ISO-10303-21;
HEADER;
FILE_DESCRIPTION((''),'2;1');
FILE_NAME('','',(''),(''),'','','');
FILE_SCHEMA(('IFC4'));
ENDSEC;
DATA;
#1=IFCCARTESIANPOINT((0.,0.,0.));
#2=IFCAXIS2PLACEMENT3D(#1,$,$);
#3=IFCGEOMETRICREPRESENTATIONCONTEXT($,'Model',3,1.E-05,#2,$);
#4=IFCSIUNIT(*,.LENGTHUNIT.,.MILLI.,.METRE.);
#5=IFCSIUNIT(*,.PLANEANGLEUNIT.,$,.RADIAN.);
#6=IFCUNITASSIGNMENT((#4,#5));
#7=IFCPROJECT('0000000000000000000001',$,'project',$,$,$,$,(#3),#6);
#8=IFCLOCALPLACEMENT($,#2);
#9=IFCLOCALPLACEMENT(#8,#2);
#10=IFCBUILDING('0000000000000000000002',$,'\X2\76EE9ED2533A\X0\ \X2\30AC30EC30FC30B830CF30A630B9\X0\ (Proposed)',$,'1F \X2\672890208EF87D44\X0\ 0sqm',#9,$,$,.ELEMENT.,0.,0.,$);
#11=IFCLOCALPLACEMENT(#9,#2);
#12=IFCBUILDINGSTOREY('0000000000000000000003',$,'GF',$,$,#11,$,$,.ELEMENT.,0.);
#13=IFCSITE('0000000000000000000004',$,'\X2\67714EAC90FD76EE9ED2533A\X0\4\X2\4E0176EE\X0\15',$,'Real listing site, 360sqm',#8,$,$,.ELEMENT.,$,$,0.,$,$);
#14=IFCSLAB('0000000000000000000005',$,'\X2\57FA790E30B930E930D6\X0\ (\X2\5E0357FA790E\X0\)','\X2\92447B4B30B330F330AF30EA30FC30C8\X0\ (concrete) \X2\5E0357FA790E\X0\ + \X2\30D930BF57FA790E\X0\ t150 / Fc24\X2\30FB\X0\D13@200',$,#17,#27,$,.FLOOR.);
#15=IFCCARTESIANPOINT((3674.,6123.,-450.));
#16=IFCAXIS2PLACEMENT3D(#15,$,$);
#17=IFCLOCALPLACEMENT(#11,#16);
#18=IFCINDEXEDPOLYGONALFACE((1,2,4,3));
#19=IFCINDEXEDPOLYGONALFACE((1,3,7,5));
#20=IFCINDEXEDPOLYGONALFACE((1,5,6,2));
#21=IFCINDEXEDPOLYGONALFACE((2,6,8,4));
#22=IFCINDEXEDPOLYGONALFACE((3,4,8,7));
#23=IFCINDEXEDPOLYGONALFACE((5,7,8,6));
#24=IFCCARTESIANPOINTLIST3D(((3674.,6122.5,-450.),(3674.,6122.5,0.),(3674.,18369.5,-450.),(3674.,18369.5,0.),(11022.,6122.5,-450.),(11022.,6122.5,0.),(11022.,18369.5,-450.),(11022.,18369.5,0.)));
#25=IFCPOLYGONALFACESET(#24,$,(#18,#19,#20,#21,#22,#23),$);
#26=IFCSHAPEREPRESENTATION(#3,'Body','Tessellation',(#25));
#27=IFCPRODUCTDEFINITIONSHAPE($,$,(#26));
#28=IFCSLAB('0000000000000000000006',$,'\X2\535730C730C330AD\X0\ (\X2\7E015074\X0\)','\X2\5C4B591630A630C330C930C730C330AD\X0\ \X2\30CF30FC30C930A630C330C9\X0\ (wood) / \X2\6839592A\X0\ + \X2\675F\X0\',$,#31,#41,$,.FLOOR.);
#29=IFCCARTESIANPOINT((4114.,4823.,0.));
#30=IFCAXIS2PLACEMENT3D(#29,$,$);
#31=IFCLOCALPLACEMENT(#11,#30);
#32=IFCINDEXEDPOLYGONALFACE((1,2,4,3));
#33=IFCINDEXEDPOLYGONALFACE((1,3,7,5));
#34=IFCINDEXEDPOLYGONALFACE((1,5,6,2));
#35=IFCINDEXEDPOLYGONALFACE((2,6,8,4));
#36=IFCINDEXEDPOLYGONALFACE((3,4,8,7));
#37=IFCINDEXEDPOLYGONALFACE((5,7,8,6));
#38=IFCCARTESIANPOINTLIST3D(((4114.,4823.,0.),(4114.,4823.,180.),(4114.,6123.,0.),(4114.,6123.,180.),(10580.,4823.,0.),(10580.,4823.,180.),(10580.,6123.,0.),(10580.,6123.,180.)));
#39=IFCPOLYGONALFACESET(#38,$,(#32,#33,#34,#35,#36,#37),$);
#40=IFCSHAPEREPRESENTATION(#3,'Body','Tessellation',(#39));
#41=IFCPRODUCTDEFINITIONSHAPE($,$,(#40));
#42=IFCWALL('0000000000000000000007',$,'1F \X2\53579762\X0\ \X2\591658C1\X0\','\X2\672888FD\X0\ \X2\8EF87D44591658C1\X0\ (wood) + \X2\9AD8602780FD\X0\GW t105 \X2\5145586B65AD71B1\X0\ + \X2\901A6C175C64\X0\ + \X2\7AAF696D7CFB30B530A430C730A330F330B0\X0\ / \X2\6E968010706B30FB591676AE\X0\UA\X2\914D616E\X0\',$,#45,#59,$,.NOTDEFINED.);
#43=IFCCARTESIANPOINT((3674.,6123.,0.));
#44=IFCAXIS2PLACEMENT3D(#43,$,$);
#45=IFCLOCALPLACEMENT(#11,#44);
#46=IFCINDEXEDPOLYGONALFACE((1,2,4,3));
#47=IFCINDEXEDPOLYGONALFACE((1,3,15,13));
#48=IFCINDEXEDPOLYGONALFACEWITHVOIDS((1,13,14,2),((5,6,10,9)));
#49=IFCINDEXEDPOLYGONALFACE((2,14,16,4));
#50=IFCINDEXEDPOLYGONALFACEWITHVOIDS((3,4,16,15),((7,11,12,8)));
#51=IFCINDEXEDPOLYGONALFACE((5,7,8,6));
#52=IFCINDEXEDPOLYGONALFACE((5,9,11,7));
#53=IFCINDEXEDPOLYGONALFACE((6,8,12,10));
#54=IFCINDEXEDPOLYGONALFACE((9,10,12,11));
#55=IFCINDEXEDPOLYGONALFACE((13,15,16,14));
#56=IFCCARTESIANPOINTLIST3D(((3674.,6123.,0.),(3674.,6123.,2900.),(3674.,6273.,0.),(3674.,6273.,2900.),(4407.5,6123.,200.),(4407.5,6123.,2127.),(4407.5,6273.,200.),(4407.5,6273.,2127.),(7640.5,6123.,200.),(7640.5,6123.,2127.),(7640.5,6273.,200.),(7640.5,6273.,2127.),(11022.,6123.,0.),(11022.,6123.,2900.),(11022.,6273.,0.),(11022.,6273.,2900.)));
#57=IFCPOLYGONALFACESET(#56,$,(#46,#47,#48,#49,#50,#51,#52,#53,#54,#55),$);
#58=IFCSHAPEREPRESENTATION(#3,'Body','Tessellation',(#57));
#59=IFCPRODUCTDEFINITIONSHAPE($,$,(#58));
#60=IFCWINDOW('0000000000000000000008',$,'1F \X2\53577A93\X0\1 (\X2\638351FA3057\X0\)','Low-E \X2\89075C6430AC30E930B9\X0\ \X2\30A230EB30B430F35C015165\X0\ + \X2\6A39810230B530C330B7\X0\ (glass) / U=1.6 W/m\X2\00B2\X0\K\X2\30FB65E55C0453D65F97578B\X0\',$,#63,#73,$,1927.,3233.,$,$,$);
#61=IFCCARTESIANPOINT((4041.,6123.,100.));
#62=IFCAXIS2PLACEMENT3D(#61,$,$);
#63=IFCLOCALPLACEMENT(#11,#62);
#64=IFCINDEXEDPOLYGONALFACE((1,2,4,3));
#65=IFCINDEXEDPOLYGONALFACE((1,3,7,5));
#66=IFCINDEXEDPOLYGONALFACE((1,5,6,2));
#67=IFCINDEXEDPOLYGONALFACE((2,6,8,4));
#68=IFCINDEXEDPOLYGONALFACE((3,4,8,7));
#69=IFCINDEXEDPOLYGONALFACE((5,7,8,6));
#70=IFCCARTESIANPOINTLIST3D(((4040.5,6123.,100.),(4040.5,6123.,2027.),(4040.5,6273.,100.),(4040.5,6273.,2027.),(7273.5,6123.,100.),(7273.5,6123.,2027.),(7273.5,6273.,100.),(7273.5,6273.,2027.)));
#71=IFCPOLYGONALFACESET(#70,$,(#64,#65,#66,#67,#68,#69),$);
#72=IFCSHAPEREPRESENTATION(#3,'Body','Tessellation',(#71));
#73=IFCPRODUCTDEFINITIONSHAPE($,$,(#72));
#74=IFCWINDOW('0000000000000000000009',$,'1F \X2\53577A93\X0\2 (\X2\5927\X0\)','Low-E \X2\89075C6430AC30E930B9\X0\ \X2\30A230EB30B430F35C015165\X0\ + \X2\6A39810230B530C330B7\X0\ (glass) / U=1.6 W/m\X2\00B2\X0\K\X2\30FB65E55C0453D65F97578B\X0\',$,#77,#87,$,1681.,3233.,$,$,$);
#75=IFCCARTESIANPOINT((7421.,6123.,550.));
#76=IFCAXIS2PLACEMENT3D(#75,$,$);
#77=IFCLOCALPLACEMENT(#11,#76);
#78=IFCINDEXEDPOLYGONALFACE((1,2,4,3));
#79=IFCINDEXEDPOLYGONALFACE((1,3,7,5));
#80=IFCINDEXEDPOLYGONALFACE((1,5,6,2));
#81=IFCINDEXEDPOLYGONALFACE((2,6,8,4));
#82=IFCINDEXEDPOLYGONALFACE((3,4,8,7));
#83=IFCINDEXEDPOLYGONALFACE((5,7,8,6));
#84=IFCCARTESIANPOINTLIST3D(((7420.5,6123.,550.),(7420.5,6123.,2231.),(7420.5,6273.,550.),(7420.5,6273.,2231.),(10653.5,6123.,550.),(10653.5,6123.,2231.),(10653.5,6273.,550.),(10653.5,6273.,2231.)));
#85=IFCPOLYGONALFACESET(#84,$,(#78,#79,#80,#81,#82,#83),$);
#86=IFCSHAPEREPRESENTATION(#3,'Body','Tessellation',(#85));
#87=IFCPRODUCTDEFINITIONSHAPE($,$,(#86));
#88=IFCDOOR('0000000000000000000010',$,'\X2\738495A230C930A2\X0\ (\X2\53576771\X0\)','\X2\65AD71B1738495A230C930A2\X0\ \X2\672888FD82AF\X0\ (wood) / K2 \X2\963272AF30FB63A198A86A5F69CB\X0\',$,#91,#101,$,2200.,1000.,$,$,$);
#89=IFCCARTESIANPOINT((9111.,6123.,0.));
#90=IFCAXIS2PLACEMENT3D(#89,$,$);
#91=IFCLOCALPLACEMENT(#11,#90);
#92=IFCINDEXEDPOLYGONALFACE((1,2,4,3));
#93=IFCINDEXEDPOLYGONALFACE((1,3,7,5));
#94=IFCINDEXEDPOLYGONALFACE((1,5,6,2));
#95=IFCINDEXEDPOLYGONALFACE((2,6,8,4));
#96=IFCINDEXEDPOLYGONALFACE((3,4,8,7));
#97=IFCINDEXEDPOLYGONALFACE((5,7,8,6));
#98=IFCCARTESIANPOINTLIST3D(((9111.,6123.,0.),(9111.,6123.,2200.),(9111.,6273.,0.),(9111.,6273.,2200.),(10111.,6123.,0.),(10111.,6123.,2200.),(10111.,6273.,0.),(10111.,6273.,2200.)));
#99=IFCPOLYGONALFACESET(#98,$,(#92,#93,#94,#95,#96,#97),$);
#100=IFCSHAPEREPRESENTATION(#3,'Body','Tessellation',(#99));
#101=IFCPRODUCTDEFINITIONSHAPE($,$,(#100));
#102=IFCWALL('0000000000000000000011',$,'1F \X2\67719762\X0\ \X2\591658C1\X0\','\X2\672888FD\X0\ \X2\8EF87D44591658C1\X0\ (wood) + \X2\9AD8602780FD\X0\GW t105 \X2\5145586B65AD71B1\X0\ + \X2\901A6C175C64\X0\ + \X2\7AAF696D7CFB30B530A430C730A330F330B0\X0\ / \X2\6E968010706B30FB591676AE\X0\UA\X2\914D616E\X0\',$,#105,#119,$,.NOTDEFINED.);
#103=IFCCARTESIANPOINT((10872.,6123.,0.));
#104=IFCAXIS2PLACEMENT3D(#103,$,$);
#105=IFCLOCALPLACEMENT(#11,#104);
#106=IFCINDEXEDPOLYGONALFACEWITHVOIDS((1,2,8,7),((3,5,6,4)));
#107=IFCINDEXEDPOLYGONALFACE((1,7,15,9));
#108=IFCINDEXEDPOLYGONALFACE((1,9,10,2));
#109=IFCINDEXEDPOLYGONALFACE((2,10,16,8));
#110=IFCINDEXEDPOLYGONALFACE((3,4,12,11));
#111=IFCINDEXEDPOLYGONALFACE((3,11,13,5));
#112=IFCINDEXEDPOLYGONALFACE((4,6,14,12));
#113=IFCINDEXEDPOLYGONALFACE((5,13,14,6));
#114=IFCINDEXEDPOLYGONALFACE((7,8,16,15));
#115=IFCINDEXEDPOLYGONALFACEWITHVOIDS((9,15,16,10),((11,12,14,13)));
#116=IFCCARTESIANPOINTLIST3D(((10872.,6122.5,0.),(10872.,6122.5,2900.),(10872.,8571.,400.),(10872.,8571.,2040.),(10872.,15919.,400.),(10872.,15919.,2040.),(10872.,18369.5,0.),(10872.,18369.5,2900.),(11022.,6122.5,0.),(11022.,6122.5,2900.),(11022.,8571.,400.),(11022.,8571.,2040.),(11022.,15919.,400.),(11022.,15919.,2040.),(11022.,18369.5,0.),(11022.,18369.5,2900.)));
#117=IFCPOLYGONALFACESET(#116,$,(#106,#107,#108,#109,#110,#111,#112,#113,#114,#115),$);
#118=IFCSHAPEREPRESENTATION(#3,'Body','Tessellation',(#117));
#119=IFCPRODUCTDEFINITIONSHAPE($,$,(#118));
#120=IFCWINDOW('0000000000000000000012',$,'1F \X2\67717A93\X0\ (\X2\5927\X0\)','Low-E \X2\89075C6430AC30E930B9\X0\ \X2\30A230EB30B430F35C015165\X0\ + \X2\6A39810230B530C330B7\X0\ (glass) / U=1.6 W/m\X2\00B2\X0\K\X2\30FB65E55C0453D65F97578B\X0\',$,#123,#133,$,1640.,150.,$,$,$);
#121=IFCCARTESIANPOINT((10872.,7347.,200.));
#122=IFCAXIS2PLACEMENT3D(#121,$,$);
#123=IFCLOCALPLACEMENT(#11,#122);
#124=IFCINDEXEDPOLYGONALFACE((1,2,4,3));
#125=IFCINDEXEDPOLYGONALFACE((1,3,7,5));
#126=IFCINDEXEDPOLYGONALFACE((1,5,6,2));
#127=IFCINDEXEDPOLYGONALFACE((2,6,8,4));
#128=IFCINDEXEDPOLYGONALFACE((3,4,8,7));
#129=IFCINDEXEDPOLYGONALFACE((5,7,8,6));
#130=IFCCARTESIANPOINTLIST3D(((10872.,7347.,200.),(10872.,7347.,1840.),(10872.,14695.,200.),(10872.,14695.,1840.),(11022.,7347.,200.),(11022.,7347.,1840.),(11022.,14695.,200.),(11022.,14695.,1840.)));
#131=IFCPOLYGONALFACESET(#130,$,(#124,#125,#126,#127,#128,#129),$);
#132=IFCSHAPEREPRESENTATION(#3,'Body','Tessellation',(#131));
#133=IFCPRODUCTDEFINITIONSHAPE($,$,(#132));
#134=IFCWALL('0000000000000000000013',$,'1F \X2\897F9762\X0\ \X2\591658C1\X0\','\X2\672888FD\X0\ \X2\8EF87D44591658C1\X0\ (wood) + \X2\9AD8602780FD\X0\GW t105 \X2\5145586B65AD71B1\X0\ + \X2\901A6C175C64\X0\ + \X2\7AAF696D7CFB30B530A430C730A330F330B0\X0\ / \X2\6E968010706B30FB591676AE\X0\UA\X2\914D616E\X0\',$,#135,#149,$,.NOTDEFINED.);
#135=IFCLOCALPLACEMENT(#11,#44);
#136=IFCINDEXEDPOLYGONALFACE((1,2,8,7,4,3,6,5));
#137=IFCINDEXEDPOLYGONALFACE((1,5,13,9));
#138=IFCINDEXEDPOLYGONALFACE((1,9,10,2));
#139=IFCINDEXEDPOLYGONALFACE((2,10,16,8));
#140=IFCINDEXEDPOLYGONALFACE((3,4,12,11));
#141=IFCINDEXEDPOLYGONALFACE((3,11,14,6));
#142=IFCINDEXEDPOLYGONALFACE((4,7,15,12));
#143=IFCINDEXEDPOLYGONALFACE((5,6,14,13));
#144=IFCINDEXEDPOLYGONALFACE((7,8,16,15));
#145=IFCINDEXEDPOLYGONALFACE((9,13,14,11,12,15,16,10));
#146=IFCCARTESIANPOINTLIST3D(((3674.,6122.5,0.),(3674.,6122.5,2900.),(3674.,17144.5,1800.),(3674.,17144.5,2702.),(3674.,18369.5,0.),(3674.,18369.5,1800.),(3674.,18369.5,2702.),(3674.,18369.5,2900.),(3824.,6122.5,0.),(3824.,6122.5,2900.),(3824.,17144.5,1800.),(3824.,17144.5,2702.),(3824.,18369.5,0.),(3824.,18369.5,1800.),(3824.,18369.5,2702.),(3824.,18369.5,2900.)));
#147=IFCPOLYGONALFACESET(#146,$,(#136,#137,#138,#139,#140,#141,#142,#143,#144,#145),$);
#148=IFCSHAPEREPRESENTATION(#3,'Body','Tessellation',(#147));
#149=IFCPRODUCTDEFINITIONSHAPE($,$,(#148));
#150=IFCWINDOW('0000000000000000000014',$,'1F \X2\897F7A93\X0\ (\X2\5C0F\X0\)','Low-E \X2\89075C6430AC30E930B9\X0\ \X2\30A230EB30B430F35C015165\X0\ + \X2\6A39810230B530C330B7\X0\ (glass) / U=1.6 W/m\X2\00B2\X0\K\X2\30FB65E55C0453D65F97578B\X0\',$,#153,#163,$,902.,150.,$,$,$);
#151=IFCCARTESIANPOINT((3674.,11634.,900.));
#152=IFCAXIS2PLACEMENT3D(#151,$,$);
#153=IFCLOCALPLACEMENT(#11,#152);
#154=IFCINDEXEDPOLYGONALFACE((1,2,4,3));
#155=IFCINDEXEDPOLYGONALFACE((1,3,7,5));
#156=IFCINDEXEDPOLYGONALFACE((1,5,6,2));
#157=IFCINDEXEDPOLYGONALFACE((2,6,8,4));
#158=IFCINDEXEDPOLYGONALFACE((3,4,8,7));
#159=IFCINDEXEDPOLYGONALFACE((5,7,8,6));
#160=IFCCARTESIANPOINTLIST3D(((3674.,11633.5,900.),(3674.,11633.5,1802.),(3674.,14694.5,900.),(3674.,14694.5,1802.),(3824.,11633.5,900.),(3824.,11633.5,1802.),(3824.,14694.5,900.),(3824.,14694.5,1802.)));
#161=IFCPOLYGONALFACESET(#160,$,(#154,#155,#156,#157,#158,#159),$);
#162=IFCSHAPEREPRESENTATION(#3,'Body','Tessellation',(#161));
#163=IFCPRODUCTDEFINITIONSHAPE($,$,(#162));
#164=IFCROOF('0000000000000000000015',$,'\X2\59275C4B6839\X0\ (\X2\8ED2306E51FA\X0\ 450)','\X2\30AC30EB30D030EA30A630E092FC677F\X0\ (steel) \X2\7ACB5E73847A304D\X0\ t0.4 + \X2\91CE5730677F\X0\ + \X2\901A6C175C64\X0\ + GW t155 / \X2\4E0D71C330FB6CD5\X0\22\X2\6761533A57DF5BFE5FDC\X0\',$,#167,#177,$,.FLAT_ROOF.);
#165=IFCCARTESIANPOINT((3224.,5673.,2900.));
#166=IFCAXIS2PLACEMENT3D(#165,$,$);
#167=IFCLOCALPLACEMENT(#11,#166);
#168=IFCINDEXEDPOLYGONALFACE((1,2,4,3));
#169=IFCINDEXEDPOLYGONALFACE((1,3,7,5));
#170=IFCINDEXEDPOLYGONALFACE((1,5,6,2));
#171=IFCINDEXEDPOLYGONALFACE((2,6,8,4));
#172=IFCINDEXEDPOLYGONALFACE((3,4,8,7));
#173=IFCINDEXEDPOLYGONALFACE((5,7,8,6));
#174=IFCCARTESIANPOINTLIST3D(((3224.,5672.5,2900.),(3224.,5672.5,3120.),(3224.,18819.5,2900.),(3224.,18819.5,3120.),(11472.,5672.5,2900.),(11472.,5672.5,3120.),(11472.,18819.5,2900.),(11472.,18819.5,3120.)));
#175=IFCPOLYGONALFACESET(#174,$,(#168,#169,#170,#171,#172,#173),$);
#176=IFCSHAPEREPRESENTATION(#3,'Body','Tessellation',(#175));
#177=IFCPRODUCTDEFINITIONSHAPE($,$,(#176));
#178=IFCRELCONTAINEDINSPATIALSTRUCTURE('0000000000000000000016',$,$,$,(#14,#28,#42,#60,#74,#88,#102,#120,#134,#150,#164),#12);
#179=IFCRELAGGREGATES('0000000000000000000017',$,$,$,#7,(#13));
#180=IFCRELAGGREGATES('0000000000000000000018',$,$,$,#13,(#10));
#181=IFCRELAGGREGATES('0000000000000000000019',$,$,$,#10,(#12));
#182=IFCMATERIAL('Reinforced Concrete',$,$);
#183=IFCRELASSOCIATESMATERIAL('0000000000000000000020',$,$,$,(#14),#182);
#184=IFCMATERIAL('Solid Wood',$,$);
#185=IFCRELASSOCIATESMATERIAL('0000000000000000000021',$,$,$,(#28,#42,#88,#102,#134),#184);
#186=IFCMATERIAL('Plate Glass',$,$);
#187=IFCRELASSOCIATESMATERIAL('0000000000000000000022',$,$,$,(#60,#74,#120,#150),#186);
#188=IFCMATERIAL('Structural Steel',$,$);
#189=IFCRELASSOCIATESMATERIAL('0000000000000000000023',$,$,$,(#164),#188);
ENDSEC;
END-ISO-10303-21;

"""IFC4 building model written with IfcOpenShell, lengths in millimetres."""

from ifc_helpers import new_model, si_unit, frame, frame_2d, origin, place, context, project, spatial, rectangle, extrude, material, element, fill, save


model = new_model("IFC4")

# Units and contexts
model_context = context("Model", 3, precision=1e-05, world=origin())
ifc_project = project(units=[si_unit("LENGTHUNIT", "METRE", prefix="MILLI"), si_unit("PLANEANGLEUNIT", "RADIAN")], contexts=[model_context])

# Site, building, storey
site_placement = place(None, origin())
site = spatial("IfcSite", under=ifc_project, at=site_placement, Name="東京都目黒区4丁目15", ObjectType="Real listing site, 360sqm", CompositionType="ELEMENT", RefElevation=0.0)
building_placement = place(site_placement, origin())
building = spatial("IfcBuilding", under=site, at=building_placement, Name="目黒区 ガレージハウス (Proposed)", ObjectType="1F 木造軸組 0sqm", CompositionType="ELEMENT", ElevationOfRefHeight=0.0, ElevationOfTerrain=0.0)
storey_placement = place(building_placement, origin())
storey = spatial("IfcBuildingStorey", under=building, at=storey_placement, Name="GF", CompositionType="ELEMENT", Elevation=0.0)

# Slabs
ifc_material_1 = material(Name="Reinforced Concrete")
slab_1_placement = place(storey_placement, frame((3674.0, 6123.0, -450.0)))
element("IfcSlab", 1, at=slab_1_placement, inside=storey, material=ifc_material_1, Name="基礎スラブ (布基礎)", Description="鉄筋コンクリート (concrete) 布基礎 + ベタ基礎 t150 / Fc24・D13@200", PredefinedType="FLOOR", context=model_context, shape_type="SweptSolid", body=[
    extrude(rectangle(XDim=7348.0, YDim=12247.0, at=frame_2d((3674.0, 6123.0))), frame((3674.0, 6123.0, -450.0)), (0.0, 0.0, 1.0), 450.0),
])
ifc_material_2 = material(Name="Solid Wood")
slab_2_placement = place(storey_placement, frame((4114.0, 4823.0, 0.0)))
element("IfcSlab", 2, at=slab_2_placement, inside=storey, material=ifc_material_2, Name="南デッキ (縁側)", Description="屋外ウッドデッキ ハードウッド (wood) / 根太 + 束", PredefinedType="FLOOR", context=model_context, shape_type="SweptSolid", body=[
    extrude(rectangle(XDim=6466.0, YDim=1300.0, at=frame_2d((3233.0, 650.0))), frame((4114.0, 4823.0, 0.0)), (0.0, 0.0, 1.0), 180.0),
])

# Wall, openings, windows, door
wall_1_placement = place(storey_placement, frame((3674.0, 6123.0, 0.0)))
wall_1 = element("IfcWall", 3, at=wall_1_placement, inside=storey, material=ifc_material_2, Name="1F 南面 外壁", Description="木製 軸組外壁 (wood) + 高性能GW t105 充填断熱 + 通気層 + 窯業系サイディング / 準耐火・外皮UA配慮", PredefinedType="NOTDEFINED", context=model_context, shape_type="SweptSolid", body=[
    extrude(rectangle(XDim=7348.0, YDim=150.0, at=frame_2d((3674.0, 75.0))), frame((3674.0, 6123.0, 0.0)), (0.0, 0.0, 1.0), 2900.0),
])
opening_1_placement = place(storey_placement, frame((4041.0, 6123.0, 100.0)))
opening_1 = element("IfcOpeningElement", 4, at=opening_1_placement, cuts=wall_1, PredefinedType="NOTDEFINED", context=model_context, shape_type="SweptSolid", body=[
    extrude(rectangle(XDim=3233.0, YDim=150.0, at=frame_2d((1616.0, 75.0))), frame((4041.0, 6123.0, 100.0)), (0.0, 0.0, 1.0), 1927.0),
])
opening_2_placement = place(storey_placement, frame((7421.0, 6123.0, 550.0)))
opening_2 = element("IfcOpeningElement", 5, at=opening_2_placement, cuts=wall_1, PredefinedType="NOTDEFINED", context=model_context, shape_type="SweptSolid", body=[
    extrude(rectangle(XDim=3233.0, YDim=150.0, at=frame_2d((1616.0, 75.0))), frame((7421.0, 6123.0, 550.0)), (0.0, 0.0, 1.0), 1681.0),
])
opening_3_placement = place(storey_placement, frame((9111.0, 6123.0, 0.0)))
opening_3 = element("IfcOpeningElement", 6, at=opening_3_placement, cuts=wall_1, PredefinedType="NOTDEFINED", context=model_context, shape_type="SweptSolid", body=[
    extrude(rectangle(XDim=1000.0, YDim=150.0, at=frame_2d((500.0, 75.0))), frame((9111.0, 6123.0, 0.0)), (0.0, 0.0, 1.0), 2200.0),
])
ifc_material_3 = material(Name="Plate Glass")
window_1_placement = place(storey_placement, frame((4041.0, 6123.0, 100.0)))
window_1 = element("IfcWindow", 7, at=window_1_placement, inside=storey, material=ifc_material_3, Name="1F 南窓1 (掃出し)", Description="Low-E 複層ガラス アルゴン封入 + 樹脂サッシ (glass) / U=1.6 W/m²K・日射取得型", OverallHeight=1927.0, OverallWidth=3233.0, context=model_context, shape_type="SweptSolid", body=[
    extrude(rectangle(XDim=3233.0, YDim=150.0, at=frame_2d((1616.0, 75.0))), frame((4041.0, 6123.0, 100.0)), (0.0, 0.0, 1.0), 1927.0),
])
fill(opening_1, window_1)
window_2_placement = place(storey_placement, frame((7421.0, 6123.0, 550.0)))
window_2 = element("IfcWindow", 8, at=window_2_placement, inside=storey, material=ifc_material_3, Name="1F 南窓2 (大)", Description="Low-E 複層ガラス アルゴン封入 + 樹脂サッシ (glass) / U=1.6 W/m²K・日射取得型", OverallHeight=1681.0, OverallWidth=3233.0, context=model_context, shape_type="SweptSolid", body=[
    extrude(rectangle(XDim=3233.0, YDim=150.0, at=frame_2d((1616.0, 75.0))), frame((7421.0, 6123.0, 550.0)), (0.0, 0.0, 1.0), 1681.0),
])
fill(opening_2, window_2)
door_placement = place(storey_placement, frame((9111.0, 6123.0, 0.0)))
door = element("IfcDoor", 9, at=door_placement, inside=storey, material=ifc_material_2, Name="玄関ドア (南東)", Description="断熱玄関ドア 木製芯 (wood) / K2 防犯・採風機構", OverallHeight=2200.0, OverallWidth=1000.0, context=model_context, shape_type="SweptSolid", body=[
    extrude(rectangle(XDim=1000.0, YDim=150.0, at=frame_2d((500.0, 75.0))), frame((9111.0, 6123.0, 0.0)), (0.0, 0.0, 1.0), 2200.0),
])
fill(opening_3, door)

# Walls, openings, windows
wall_2_placement = place(storey_placement, frame((10872.0, 6123.0, 0.0)))
wall_2 = element("IfcWall", 10, at=wall_2_placement, inside=storey, material=ifc_material_2, Name="1F 東面 外壁", Description="木製 軸組外壁 (wood) + 高性能GW t105 充填断熱 + 通気層 + 窯業系サイディング / 準耐火・外皮UA配慮", PredefinedType="NOTDEFINED", context=model_context, shape_type="SweptSolid", body=[
    extrude(rectangle(XDim=150.0, YDim=12247.0, at=frame_2d((75.0, 6123.0))), frame((10872.0, 6123.0, 0.0)), (0.0, 0.0, 1.0), 2900.0),
])
opening_4_placement = place(storey_placement, frame((10872.0, 7347.0, 200.0)))
opening_4 = element("IfcOpeningElement", 11, at=opening_4_placement, cuts=wall_2, PredefinedType="NOTDEFINED", context=model_context, shape_type="SweptSolid", body=[
    extrude(rectangle(XDim=150.0, YDim=7348.0, at=frame_2d((75.0, 3674.0))), frame((10872.0, 7347.0, 200.0)), (0.0, 0.0, 1.0), 1640.0),
])
window_3_placement = place(storey_placement, frame((10872.0, 7347.0, 200.0)))
window_3 = element("IfcWindow", 12, at=window_3_placement, inside=storey, material=ifc_material_3, Name="1F 東窓 (大)", Description="Low-E 複層ガラス アルゴン封入 + 樹脂サッシ (glass) / U=1.6 W/m²K・日射取得型", OverallHeight=1640.0, OverallWidth=150.0, context=model_context, shape_type="SweptSolid", body=[
    extrude(rectangle(XDim=150.0, YDim=7348.0, at=frame_2d((75.0, 3674.0))), frame((10872.0, 7347.0, 200.0)), (0.0, 0.0, 1.0), 1640.0),
])
fill(opening_4, window_3)
wall_3_placement = place(storey_placement, frame((3674.0, 6123.0, 0.0)))
wall_3 = element("IfcWall", 13, at=wall_3_placement, inside=storey, material=ifc_material_2, Name="1F 西面 外壁", Description="木製 軸組外壁 (wood) + 高性能GW t105 充填断熱 + 通気層 + 窯業系サイディング / 準耐火・外皮UA配慮", PredefinedType="NOTDEFINED", context=model_context, shape_type="SweptSolid", body=[
    extrude(rectangle(XDim=150.0, YDim=12247.0, at=frame_2d((75.0, 6123.0))), frame((3674.0, 6123.0, 0.0)), (0.0, 0.0, 1.0), 2900.0),
])
opening_5_placement = place(storey_placement, frame((3674.0, 11634.0, 900.0)))
opening_5 = element("IfcOpeningElement", 14, at=opening_5_placement, cuts=wall_3, PredefinedType="NOTDEFINED", context=model_context, shape_type="SweptSolid", body=[
    extrude(rectangle(XDim=150.0, YDim=3061.0, at=frame_2d((75.0, 1530.0))), frame((3674.0, 11634.0, 900.0)), (0.0, 0.0, 1.0), 902.0),
])
window_4_placement = place(storey_placement, frame((3674.0, 11634.0, 900.0)))
window_4 = element("IfcWindow", 15, at=window_4_placement, inside=storey, material=ifc_material_3, Name="1F 西窓 (小)", Description="Low-E 複層ガラス アルゴン封入 + 樹脂サッシ (glass) / U=1.6 W/m²K・日射取得型", OverallHeight=902.0, OverallWidth=150.0, context=model_context, shape_type="SweptSolid", body=[
    extrude(rectangle(XDim=150.0, YDim=3061.0, at=frame_2d((75.0, 1530.0))), frame((3674.0, 11634.0, 900.0)), (0.0, 0.0, 1.0), 902.0),
])
fill(opening_5, window_4)

# Roof
ifc_material_4 = material(Name="Structural Steel")
roof_placement = place(storey_placement, frame((3224.0, 5673.0, 2900.0)))
element("IfcRoof", 16, at=roof_placement, inside=storey, material=ifc_material_4, Name="大屋根 (軒の出 450)", Description="ガルバリウム鋼板 (steel) 立平葺き t0.4 + 野地板 + 通気層 + GW t155 / 不燃・法22条区域対応", PredefinedType="FLAT_ROOF", context=model_context, shape_type="SweptSolid", body=[
    extrude(rectangle(XDim=8248.0, YDim=13147.0, at=frame_2d((4124.0, 6573.0))), frame((3224.0, 5673.0, 2900.0)), (0.0, 0.0, 1.0), 220.0),
])

save(model, "model.ifc")
